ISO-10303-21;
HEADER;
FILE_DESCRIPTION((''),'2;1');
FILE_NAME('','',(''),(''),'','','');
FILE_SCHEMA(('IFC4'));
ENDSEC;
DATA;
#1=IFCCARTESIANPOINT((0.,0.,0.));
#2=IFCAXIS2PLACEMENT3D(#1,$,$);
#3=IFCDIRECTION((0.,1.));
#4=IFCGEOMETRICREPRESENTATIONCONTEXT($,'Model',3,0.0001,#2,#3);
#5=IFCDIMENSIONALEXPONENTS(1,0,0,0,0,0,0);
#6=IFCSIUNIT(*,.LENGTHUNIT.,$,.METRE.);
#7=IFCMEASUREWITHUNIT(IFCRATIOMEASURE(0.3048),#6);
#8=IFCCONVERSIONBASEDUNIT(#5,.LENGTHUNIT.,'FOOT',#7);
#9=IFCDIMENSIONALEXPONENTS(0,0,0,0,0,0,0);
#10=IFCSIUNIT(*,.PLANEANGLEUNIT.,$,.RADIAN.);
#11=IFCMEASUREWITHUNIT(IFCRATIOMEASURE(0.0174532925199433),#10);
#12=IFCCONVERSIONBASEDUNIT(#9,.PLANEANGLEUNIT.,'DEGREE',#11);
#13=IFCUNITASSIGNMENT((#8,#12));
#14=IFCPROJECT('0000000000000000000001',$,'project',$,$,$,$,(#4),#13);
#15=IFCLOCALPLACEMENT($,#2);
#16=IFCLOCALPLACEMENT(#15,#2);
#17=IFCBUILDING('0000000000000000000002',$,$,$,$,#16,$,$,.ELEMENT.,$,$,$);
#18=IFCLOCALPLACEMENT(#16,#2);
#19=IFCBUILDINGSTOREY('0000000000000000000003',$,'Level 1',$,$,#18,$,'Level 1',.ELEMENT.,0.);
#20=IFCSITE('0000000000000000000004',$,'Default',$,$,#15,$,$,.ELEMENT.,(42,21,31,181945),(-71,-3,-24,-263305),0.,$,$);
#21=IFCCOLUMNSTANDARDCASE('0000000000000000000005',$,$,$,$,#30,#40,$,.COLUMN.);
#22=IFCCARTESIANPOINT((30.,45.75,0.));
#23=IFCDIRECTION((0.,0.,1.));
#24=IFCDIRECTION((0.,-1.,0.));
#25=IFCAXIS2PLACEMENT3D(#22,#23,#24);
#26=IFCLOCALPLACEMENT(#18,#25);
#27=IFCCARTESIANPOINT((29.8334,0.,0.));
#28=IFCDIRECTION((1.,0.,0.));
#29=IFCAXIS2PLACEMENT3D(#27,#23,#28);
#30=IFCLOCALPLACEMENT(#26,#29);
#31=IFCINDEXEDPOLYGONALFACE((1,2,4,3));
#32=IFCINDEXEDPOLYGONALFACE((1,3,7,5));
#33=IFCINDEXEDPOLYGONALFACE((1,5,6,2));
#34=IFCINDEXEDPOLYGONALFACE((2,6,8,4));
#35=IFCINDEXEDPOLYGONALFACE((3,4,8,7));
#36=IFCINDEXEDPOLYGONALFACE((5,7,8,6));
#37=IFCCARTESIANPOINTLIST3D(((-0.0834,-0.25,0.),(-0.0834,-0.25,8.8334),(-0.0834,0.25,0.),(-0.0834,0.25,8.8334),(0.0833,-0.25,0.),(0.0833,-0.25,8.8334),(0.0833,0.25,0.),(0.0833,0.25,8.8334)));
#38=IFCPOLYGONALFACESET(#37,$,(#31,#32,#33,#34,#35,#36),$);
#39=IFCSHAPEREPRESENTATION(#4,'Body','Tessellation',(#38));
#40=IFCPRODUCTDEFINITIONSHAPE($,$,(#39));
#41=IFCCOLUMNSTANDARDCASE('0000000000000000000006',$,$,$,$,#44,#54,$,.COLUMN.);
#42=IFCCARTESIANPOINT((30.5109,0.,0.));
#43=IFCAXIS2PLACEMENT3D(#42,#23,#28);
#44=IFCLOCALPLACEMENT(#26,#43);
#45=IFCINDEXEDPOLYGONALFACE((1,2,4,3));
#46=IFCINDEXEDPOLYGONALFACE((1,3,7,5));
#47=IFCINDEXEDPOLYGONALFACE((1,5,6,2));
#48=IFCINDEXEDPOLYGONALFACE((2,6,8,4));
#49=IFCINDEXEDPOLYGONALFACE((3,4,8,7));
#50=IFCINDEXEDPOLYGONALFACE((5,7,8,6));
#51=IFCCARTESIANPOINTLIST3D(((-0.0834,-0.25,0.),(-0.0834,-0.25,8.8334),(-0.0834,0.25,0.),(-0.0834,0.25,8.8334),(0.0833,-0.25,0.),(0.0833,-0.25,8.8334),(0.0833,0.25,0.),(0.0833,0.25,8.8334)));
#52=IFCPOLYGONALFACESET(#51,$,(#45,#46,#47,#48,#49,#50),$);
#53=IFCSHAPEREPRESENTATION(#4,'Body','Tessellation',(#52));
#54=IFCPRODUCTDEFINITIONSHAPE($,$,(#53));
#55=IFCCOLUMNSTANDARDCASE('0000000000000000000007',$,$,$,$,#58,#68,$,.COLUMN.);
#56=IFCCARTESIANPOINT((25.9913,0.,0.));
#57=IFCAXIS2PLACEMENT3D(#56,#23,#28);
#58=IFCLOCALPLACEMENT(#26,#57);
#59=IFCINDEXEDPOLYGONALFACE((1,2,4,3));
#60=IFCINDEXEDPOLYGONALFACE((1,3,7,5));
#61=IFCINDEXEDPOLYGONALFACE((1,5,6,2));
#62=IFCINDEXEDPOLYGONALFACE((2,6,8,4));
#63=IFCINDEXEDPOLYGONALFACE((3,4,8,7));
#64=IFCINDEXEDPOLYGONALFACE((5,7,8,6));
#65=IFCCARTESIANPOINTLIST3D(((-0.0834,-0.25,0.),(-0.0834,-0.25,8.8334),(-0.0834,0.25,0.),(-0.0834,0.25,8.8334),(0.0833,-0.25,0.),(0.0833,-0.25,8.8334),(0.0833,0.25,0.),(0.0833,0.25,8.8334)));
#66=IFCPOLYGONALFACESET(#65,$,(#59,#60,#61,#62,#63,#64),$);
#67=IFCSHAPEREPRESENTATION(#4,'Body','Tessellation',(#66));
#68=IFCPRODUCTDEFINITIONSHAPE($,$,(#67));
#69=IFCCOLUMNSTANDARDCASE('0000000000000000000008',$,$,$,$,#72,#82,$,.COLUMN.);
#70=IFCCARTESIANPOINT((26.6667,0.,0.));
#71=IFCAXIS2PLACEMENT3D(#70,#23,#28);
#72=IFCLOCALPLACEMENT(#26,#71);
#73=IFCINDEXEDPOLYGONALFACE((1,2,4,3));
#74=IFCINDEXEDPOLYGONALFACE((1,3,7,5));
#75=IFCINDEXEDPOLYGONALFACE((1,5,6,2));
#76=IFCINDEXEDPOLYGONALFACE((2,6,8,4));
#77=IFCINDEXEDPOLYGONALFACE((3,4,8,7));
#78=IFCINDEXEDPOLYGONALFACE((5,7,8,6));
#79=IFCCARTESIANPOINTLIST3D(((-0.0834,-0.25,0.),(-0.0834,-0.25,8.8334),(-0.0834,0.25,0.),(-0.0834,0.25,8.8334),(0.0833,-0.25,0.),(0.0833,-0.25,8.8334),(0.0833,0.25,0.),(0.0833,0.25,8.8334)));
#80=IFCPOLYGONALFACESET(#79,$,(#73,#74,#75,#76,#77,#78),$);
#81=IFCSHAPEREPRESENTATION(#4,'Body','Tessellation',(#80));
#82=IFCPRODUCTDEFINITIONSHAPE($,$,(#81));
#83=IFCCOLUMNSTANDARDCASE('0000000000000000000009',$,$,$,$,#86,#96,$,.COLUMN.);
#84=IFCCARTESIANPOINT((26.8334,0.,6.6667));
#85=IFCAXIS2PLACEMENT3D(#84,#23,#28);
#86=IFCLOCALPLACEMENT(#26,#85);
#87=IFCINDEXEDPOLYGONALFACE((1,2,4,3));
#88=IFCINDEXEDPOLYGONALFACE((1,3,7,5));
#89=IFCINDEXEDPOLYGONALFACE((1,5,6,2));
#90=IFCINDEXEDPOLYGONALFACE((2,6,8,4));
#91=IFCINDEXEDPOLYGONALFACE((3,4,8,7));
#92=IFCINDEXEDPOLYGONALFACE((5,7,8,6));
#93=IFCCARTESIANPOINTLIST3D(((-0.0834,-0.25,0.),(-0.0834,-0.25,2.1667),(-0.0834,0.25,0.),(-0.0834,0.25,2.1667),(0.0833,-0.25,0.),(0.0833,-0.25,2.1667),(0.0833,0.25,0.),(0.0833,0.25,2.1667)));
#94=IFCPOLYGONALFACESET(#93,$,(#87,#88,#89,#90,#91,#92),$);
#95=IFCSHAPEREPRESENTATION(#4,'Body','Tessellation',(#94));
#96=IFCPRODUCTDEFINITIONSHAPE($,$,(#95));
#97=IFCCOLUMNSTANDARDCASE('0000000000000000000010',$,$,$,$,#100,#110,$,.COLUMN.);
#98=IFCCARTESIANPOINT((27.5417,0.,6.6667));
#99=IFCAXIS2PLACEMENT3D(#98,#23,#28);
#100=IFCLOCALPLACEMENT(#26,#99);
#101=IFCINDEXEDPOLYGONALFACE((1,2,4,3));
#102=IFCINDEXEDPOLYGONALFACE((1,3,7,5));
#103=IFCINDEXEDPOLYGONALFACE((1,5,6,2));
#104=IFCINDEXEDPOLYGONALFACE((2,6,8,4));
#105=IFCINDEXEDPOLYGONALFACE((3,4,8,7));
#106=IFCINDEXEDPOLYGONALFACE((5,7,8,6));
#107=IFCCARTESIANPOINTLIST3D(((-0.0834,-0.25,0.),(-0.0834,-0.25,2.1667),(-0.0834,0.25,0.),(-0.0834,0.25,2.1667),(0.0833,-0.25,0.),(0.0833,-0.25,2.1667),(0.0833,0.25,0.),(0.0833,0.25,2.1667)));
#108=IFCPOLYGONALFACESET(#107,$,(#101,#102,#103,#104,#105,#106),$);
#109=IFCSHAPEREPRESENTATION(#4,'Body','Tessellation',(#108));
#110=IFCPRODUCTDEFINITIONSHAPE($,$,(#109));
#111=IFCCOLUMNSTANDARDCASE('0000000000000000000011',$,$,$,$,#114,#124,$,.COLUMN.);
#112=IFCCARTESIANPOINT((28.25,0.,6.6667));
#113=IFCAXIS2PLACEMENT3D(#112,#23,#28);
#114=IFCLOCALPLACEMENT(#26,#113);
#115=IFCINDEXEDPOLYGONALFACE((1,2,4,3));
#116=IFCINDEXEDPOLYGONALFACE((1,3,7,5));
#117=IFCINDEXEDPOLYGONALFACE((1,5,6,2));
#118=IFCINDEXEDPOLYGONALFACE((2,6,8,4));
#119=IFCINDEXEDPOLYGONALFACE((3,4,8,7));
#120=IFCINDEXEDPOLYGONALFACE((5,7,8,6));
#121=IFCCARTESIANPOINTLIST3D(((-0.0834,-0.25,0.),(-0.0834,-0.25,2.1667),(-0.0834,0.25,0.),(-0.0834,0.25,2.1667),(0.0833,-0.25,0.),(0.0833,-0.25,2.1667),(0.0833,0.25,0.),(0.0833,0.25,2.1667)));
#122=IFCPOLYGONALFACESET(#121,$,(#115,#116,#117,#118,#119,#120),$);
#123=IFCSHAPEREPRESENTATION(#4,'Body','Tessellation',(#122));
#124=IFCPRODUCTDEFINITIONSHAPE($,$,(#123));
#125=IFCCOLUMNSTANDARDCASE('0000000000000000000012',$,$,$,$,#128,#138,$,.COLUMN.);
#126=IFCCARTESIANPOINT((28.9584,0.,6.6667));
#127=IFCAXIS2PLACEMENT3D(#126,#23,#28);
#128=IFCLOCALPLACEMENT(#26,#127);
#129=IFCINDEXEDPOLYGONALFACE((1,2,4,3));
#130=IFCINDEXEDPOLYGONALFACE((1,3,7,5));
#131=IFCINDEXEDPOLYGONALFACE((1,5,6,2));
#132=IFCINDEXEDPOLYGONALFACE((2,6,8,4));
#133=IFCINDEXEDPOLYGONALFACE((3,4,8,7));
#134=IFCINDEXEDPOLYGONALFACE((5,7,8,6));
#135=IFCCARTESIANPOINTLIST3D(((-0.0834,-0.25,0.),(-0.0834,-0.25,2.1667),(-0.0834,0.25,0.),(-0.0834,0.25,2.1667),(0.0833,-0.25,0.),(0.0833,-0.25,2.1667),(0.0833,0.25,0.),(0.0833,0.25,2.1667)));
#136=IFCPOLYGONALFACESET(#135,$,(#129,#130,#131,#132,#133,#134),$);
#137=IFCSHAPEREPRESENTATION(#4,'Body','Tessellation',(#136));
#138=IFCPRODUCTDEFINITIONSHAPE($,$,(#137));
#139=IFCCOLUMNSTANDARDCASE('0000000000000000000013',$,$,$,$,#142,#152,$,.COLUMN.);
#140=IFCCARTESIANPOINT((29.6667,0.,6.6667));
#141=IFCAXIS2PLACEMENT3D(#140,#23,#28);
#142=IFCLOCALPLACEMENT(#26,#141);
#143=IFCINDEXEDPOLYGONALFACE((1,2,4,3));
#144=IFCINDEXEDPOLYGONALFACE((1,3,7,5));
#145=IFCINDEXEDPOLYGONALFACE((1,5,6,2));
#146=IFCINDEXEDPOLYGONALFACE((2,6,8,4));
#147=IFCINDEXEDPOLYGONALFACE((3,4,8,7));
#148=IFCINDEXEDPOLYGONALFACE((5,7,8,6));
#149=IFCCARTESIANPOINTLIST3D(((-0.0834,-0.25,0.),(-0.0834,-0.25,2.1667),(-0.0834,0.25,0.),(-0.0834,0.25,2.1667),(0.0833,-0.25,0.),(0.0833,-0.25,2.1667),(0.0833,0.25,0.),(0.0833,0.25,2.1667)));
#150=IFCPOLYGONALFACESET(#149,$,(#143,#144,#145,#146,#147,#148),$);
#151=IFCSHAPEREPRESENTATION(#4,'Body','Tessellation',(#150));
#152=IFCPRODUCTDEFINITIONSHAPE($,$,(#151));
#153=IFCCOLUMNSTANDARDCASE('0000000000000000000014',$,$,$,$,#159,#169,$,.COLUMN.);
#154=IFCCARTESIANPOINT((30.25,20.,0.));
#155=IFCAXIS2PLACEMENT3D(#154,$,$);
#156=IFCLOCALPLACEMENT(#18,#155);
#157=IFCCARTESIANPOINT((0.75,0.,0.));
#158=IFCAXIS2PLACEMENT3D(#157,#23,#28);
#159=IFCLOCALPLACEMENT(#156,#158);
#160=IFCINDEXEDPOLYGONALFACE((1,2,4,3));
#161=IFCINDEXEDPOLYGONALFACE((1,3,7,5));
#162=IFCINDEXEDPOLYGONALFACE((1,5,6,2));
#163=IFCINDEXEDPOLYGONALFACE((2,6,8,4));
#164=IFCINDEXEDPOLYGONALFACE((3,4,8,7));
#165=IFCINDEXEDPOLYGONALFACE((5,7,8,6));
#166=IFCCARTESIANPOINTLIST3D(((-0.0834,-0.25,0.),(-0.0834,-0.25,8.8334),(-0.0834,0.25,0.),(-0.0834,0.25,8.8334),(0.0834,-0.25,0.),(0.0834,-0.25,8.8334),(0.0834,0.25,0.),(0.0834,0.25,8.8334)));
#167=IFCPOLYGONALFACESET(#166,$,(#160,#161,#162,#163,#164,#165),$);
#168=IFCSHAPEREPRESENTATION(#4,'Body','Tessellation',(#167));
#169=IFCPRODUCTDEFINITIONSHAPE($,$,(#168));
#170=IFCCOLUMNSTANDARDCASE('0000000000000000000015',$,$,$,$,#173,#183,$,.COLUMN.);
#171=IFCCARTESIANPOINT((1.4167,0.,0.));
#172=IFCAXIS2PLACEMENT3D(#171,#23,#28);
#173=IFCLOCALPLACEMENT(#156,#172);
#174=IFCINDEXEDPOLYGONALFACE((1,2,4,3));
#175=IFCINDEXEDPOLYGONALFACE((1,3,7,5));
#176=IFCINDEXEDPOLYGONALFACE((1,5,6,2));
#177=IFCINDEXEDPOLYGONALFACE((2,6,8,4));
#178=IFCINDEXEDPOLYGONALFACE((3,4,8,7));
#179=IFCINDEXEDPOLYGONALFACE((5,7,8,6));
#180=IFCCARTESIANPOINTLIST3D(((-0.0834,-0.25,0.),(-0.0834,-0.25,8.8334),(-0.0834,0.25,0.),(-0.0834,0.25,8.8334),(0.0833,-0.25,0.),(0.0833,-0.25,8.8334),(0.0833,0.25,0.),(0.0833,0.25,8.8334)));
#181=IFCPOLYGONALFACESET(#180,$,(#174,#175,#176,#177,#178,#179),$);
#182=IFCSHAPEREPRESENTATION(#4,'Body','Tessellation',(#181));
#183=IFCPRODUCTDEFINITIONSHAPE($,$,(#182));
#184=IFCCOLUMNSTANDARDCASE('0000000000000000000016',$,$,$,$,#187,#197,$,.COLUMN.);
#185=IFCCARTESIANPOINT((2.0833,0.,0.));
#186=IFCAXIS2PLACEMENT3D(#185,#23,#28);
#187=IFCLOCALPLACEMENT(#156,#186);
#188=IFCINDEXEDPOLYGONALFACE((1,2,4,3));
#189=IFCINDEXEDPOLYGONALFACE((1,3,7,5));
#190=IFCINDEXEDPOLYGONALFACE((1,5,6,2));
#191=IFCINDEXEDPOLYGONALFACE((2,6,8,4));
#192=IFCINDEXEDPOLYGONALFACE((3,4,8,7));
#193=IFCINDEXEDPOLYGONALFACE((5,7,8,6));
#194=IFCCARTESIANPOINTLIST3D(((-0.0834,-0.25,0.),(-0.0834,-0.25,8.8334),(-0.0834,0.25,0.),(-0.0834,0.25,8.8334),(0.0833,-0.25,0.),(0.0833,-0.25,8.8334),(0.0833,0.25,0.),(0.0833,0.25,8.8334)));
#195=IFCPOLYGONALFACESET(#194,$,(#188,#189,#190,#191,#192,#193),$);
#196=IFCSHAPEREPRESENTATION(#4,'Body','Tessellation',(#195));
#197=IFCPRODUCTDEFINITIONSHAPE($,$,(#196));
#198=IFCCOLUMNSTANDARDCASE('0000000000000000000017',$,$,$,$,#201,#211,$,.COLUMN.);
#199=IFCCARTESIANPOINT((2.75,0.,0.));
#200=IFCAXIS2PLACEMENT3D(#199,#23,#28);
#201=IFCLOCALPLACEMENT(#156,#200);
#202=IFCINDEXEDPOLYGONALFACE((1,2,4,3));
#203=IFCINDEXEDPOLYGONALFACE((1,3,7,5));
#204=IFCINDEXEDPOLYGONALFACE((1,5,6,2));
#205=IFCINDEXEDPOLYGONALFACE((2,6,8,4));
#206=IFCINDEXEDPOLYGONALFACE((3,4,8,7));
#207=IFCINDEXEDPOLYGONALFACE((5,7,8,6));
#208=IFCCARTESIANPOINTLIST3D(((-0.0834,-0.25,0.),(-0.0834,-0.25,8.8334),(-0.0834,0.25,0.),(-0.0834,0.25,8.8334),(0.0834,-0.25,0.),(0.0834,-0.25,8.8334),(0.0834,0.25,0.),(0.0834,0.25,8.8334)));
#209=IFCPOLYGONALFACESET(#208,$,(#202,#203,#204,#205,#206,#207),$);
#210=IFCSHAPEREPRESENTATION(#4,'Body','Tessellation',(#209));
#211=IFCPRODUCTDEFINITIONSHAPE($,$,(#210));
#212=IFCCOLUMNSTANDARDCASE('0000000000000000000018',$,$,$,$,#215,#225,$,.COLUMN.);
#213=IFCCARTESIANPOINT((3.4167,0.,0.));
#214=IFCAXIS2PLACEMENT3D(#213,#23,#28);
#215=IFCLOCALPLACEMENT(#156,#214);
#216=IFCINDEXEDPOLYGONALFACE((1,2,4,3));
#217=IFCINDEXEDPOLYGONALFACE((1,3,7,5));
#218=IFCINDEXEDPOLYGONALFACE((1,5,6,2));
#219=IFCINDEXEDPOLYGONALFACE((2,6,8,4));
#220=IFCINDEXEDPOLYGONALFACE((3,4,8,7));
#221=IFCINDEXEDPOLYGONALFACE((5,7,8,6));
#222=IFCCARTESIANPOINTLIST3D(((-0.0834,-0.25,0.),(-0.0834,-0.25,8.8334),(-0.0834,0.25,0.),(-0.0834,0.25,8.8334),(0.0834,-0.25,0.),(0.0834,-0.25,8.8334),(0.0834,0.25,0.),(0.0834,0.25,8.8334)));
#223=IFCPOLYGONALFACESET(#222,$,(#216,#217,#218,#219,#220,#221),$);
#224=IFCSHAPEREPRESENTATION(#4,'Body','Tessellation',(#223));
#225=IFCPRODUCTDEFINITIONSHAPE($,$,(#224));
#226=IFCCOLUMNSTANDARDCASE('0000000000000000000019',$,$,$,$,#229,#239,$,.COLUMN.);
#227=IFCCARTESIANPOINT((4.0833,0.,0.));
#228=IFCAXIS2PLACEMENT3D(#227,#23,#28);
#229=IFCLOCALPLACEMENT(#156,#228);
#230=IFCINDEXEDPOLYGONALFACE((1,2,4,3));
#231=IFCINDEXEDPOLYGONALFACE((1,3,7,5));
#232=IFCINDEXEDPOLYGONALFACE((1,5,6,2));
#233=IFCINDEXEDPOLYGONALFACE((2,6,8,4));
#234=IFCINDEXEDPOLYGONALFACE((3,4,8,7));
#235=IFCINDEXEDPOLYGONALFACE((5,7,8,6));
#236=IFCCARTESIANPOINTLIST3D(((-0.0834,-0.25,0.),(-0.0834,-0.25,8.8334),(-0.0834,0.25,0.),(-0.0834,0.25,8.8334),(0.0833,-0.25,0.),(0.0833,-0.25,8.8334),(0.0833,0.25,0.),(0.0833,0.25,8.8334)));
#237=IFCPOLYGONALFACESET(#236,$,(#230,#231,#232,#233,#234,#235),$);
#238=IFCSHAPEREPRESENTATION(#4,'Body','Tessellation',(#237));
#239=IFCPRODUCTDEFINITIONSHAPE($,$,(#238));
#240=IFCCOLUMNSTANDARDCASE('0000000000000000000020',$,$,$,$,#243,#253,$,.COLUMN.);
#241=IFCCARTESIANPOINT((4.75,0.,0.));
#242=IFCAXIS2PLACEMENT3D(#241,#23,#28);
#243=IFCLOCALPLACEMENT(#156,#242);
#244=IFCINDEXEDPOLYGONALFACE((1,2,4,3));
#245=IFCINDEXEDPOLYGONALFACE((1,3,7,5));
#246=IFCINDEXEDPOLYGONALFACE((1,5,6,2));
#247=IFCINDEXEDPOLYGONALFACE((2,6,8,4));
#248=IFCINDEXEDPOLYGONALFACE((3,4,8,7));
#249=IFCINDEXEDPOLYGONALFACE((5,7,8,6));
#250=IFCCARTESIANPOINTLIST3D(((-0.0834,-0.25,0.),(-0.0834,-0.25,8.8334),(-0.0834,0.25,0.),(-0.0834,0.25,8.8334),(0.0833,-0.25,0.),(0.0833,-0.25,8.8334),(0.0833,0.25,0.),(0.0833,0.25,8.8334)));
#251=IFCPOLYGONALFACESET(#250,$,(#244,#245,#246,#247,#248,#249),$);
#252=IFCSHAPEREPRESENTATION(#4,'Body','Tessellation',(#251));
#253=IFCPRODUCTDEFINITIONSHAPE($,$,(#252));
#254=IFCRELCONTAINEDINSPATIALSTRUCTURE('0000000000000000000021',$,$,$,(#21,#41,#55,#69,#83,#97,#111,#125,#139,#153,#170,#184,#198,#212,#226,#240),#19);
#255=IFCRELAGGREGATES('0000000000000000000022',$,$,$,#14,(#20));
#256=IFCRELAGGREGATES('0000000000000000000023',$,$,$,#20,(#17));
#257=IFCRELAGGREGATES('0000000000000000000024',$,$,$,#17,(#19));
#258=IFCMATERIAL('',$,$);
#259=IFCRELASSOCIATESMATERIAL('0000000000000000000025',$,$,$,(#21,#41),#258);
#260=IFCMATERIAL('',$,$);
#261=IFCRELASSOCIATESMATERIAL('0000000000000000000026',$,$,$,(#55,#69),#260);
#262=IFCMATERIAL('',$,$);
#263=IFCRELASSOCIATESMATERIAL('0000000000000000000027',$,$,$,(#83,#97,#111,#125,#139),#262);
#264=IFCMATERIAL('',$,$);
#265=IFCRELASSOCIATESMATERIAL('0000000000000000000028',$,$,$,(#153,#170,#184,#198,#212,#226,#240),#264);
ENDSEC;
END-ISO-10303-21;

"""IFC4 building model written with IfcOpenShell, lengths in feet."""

from ifc_helpers import new_model, entity, si_unit, converted_unit, direction, frame, origin, place, context, project, spatial, rectangle, extrude, material, element, save


model = new_model("IFC4")

# Units and contexts
model_context = context("Model", 3, precision=0.0001, world=origin(), true_north=direction((0.0, 1.0)))
ifc_project = project(units=[converted_unit("LENGTHUNIT", "FOOT", entity("IfcRatioMeasure", 0.3048), si_unit("LENGTHUNIT", "METRE"), dimensions=[1, 0, 0, 0, 0, 0, 0]), converted_unit("PLANEANGLEUNIT", "DEGREE", entity("IfcRatioMeasure", 0.0174532925199433), si_unit("PLANEANGLEUNIT", "RADIAN"), dimensions=[0, 0, 0, 0, 0, 0, 0])], contexts=[model_context])

# Site, building, storey
site_placement = place(None, origin())
site = spatial("IfcSite", under=ifc_project, at=site_placement, Name="Default", CompositionType="ELEMENT", RefLatitude=(42, 21, 31, 181945), RefLongitude=(-71, -3, -24, -263305), RefElevation=0.0)
building_placement = place(site_placement, origin())
building = spatial("IfcBuilding", under=site, at=building_placement, CompositionType="ELEMENT")
storey_placement = place(building_placement, origin())
storey = spatial("IfcBuildingStorey", under=building, at=storey_placement, Name="Level 1", LongName="Level 1", CompositionType="ELEMENT", Elevation=0.0)

# Columns
ifc_material_1 = material(Name="")
placement_1 = place(storey_placement, frame((30.0, 45.75, 0.0), z_axis=(0.0, 0.0, 1.0), x_axis=(0.0, -1.0, 0.0)))
for number, where, z_axis, x_axis in (
    (1, (29.8334, 0.0, 0.0), (0.0, 0.0, 1.0), (1.0, 0.0, 0.0)),
    (2, (30.5109, 0.0, 0.0), (0.0, 0.0, 1.0), (1.0, 0.0, 0.0)),
):
    element("IfcColumnStandardCase", number, at=place(placement_1, frame(where, z_axis=z_axis, x_axis=x_axis)), inside=storey, material=ifc_material_1, PredefinedType="COLUMN", context=model_context, shape_type="SweptSolid", body=[
        extrude(rectangle(XDim=0.1667, YDim=0.5), origin(), (0.0, 0.0, 1.0), 8.8334),
    ])
ifc_material_2 = material(Name="")
for number, where, z_axis, x_axis in (
    (3, (25.9913, 0.0, 0.0), (0.0, 0.0, 1.0), (1.0, 0.0, 0.0)),
    (4, (26.6667, 0.0, 0.0), (0.0, 0.0, 1.0), (1.0, 0.0, 0.0)),
):
    element("IfcColumnStandardCase", number, at=place(placement_1, frame(where, z_axis=z_axis, x_axis=x_axis)), inside=storey, material=ifc_material_2, PredefinedType="COLUMN", context=model_context, shape_type="SweptSolid", body=[
        extrude(rectangle(XDim=0.1667, YDim=0.5), origin(), (0.0, 0.0, 1.0), 8.8334),
    ])
ifc_material_3 = material(Name="")
for number, where, z_axis, x_axis in (
    (5, (26.8334, 0.0, 6.6667), (0.0, 0.0, 1.0), (1.0, 0.0, 0.0)),
    (6, (27.5417, 0.0, 6.6667), (0.0, 0.0, 1.0), (1.0, 0.0, 0.0)),
    (7, (28.25, 0.0, 6.6667), (0.0, 0.0, 1.0), (1.0, 0.0, 0.0)),
    (8, (28.9584, 0.0, 6.6667), (0.0, 0.0, 1.0), (1.0, 0.0, 0.0)),
    (9, (29.6667, 0.0, 6.6667), (0.0, 0.0, 1.0), (1.0, 0.0, 0.0)),
):
    element("IfcColumnStandardCase", number, at=place(placement_1, frame(where, z_axis=z_axis, x_axis=x_axis)), inside=storey, material=ifc_material_3, PredefinedType="COLUMN", context=model_context, shape_type="SweptSolid", body=[
        extrude(rectangle(XDim=0.1667, YDim=0.5), origin(), (0.0, 0.0, 1.0), 2.1667),
    ])
ifc_material_4 = material(Name="")
placement_2 = place(storey_placement, frame((30.25, 20.0, 0.0)))
for number, where, z_axis, x_axis in (
    (10, (0.75, 0.0, 0.0), (0.0, 0.0, 1.0), (1.0, 0.0, 0.0)),
    (11, (1.4167, 0.0, 0.0), (0.0, 0.0, 1.0), (1.0, 0.0, 0.0)),
    (12, (2.0833, 0.0, 0.0), (0.0, 0.0, 1.0), (1.0, 0.0, 0.0)),
    (13, (2.75, 0.0, 0.0), (0.0, 0.0, 1.0), (1.0, 0.0, 0.0)),
    (14, (3.4167, 0.0, 0.0), (0.0, 0.0, 1.0), (1.0, 0.0, 0.0)),
    (15, (4.0833, 0.0, 0.0), (0.0, 0.0, 1.0), (1.0, 0.0, 0.0)),
    (16, (4.75, 0.0, 0.0), (0.0, 0.0, 1.0), (1.0, 0.0, 0.0)),
):
    element("IfcColumnStandardCase", number, at=place(placement_2, frame(where, z_axis=z_axis, x_axis=x_axis)), inside=storey, material=ifc_material_4, PredefinedType="COLUMN", context=model_context, shape_type="SweptSolid", body=[
        extrude(rectangle(XDim=0.1667, YDim=0.5), origin(), (0.0, 0.0, 1.0), 8.8334),
    ])

save(model, "model.ifc")
